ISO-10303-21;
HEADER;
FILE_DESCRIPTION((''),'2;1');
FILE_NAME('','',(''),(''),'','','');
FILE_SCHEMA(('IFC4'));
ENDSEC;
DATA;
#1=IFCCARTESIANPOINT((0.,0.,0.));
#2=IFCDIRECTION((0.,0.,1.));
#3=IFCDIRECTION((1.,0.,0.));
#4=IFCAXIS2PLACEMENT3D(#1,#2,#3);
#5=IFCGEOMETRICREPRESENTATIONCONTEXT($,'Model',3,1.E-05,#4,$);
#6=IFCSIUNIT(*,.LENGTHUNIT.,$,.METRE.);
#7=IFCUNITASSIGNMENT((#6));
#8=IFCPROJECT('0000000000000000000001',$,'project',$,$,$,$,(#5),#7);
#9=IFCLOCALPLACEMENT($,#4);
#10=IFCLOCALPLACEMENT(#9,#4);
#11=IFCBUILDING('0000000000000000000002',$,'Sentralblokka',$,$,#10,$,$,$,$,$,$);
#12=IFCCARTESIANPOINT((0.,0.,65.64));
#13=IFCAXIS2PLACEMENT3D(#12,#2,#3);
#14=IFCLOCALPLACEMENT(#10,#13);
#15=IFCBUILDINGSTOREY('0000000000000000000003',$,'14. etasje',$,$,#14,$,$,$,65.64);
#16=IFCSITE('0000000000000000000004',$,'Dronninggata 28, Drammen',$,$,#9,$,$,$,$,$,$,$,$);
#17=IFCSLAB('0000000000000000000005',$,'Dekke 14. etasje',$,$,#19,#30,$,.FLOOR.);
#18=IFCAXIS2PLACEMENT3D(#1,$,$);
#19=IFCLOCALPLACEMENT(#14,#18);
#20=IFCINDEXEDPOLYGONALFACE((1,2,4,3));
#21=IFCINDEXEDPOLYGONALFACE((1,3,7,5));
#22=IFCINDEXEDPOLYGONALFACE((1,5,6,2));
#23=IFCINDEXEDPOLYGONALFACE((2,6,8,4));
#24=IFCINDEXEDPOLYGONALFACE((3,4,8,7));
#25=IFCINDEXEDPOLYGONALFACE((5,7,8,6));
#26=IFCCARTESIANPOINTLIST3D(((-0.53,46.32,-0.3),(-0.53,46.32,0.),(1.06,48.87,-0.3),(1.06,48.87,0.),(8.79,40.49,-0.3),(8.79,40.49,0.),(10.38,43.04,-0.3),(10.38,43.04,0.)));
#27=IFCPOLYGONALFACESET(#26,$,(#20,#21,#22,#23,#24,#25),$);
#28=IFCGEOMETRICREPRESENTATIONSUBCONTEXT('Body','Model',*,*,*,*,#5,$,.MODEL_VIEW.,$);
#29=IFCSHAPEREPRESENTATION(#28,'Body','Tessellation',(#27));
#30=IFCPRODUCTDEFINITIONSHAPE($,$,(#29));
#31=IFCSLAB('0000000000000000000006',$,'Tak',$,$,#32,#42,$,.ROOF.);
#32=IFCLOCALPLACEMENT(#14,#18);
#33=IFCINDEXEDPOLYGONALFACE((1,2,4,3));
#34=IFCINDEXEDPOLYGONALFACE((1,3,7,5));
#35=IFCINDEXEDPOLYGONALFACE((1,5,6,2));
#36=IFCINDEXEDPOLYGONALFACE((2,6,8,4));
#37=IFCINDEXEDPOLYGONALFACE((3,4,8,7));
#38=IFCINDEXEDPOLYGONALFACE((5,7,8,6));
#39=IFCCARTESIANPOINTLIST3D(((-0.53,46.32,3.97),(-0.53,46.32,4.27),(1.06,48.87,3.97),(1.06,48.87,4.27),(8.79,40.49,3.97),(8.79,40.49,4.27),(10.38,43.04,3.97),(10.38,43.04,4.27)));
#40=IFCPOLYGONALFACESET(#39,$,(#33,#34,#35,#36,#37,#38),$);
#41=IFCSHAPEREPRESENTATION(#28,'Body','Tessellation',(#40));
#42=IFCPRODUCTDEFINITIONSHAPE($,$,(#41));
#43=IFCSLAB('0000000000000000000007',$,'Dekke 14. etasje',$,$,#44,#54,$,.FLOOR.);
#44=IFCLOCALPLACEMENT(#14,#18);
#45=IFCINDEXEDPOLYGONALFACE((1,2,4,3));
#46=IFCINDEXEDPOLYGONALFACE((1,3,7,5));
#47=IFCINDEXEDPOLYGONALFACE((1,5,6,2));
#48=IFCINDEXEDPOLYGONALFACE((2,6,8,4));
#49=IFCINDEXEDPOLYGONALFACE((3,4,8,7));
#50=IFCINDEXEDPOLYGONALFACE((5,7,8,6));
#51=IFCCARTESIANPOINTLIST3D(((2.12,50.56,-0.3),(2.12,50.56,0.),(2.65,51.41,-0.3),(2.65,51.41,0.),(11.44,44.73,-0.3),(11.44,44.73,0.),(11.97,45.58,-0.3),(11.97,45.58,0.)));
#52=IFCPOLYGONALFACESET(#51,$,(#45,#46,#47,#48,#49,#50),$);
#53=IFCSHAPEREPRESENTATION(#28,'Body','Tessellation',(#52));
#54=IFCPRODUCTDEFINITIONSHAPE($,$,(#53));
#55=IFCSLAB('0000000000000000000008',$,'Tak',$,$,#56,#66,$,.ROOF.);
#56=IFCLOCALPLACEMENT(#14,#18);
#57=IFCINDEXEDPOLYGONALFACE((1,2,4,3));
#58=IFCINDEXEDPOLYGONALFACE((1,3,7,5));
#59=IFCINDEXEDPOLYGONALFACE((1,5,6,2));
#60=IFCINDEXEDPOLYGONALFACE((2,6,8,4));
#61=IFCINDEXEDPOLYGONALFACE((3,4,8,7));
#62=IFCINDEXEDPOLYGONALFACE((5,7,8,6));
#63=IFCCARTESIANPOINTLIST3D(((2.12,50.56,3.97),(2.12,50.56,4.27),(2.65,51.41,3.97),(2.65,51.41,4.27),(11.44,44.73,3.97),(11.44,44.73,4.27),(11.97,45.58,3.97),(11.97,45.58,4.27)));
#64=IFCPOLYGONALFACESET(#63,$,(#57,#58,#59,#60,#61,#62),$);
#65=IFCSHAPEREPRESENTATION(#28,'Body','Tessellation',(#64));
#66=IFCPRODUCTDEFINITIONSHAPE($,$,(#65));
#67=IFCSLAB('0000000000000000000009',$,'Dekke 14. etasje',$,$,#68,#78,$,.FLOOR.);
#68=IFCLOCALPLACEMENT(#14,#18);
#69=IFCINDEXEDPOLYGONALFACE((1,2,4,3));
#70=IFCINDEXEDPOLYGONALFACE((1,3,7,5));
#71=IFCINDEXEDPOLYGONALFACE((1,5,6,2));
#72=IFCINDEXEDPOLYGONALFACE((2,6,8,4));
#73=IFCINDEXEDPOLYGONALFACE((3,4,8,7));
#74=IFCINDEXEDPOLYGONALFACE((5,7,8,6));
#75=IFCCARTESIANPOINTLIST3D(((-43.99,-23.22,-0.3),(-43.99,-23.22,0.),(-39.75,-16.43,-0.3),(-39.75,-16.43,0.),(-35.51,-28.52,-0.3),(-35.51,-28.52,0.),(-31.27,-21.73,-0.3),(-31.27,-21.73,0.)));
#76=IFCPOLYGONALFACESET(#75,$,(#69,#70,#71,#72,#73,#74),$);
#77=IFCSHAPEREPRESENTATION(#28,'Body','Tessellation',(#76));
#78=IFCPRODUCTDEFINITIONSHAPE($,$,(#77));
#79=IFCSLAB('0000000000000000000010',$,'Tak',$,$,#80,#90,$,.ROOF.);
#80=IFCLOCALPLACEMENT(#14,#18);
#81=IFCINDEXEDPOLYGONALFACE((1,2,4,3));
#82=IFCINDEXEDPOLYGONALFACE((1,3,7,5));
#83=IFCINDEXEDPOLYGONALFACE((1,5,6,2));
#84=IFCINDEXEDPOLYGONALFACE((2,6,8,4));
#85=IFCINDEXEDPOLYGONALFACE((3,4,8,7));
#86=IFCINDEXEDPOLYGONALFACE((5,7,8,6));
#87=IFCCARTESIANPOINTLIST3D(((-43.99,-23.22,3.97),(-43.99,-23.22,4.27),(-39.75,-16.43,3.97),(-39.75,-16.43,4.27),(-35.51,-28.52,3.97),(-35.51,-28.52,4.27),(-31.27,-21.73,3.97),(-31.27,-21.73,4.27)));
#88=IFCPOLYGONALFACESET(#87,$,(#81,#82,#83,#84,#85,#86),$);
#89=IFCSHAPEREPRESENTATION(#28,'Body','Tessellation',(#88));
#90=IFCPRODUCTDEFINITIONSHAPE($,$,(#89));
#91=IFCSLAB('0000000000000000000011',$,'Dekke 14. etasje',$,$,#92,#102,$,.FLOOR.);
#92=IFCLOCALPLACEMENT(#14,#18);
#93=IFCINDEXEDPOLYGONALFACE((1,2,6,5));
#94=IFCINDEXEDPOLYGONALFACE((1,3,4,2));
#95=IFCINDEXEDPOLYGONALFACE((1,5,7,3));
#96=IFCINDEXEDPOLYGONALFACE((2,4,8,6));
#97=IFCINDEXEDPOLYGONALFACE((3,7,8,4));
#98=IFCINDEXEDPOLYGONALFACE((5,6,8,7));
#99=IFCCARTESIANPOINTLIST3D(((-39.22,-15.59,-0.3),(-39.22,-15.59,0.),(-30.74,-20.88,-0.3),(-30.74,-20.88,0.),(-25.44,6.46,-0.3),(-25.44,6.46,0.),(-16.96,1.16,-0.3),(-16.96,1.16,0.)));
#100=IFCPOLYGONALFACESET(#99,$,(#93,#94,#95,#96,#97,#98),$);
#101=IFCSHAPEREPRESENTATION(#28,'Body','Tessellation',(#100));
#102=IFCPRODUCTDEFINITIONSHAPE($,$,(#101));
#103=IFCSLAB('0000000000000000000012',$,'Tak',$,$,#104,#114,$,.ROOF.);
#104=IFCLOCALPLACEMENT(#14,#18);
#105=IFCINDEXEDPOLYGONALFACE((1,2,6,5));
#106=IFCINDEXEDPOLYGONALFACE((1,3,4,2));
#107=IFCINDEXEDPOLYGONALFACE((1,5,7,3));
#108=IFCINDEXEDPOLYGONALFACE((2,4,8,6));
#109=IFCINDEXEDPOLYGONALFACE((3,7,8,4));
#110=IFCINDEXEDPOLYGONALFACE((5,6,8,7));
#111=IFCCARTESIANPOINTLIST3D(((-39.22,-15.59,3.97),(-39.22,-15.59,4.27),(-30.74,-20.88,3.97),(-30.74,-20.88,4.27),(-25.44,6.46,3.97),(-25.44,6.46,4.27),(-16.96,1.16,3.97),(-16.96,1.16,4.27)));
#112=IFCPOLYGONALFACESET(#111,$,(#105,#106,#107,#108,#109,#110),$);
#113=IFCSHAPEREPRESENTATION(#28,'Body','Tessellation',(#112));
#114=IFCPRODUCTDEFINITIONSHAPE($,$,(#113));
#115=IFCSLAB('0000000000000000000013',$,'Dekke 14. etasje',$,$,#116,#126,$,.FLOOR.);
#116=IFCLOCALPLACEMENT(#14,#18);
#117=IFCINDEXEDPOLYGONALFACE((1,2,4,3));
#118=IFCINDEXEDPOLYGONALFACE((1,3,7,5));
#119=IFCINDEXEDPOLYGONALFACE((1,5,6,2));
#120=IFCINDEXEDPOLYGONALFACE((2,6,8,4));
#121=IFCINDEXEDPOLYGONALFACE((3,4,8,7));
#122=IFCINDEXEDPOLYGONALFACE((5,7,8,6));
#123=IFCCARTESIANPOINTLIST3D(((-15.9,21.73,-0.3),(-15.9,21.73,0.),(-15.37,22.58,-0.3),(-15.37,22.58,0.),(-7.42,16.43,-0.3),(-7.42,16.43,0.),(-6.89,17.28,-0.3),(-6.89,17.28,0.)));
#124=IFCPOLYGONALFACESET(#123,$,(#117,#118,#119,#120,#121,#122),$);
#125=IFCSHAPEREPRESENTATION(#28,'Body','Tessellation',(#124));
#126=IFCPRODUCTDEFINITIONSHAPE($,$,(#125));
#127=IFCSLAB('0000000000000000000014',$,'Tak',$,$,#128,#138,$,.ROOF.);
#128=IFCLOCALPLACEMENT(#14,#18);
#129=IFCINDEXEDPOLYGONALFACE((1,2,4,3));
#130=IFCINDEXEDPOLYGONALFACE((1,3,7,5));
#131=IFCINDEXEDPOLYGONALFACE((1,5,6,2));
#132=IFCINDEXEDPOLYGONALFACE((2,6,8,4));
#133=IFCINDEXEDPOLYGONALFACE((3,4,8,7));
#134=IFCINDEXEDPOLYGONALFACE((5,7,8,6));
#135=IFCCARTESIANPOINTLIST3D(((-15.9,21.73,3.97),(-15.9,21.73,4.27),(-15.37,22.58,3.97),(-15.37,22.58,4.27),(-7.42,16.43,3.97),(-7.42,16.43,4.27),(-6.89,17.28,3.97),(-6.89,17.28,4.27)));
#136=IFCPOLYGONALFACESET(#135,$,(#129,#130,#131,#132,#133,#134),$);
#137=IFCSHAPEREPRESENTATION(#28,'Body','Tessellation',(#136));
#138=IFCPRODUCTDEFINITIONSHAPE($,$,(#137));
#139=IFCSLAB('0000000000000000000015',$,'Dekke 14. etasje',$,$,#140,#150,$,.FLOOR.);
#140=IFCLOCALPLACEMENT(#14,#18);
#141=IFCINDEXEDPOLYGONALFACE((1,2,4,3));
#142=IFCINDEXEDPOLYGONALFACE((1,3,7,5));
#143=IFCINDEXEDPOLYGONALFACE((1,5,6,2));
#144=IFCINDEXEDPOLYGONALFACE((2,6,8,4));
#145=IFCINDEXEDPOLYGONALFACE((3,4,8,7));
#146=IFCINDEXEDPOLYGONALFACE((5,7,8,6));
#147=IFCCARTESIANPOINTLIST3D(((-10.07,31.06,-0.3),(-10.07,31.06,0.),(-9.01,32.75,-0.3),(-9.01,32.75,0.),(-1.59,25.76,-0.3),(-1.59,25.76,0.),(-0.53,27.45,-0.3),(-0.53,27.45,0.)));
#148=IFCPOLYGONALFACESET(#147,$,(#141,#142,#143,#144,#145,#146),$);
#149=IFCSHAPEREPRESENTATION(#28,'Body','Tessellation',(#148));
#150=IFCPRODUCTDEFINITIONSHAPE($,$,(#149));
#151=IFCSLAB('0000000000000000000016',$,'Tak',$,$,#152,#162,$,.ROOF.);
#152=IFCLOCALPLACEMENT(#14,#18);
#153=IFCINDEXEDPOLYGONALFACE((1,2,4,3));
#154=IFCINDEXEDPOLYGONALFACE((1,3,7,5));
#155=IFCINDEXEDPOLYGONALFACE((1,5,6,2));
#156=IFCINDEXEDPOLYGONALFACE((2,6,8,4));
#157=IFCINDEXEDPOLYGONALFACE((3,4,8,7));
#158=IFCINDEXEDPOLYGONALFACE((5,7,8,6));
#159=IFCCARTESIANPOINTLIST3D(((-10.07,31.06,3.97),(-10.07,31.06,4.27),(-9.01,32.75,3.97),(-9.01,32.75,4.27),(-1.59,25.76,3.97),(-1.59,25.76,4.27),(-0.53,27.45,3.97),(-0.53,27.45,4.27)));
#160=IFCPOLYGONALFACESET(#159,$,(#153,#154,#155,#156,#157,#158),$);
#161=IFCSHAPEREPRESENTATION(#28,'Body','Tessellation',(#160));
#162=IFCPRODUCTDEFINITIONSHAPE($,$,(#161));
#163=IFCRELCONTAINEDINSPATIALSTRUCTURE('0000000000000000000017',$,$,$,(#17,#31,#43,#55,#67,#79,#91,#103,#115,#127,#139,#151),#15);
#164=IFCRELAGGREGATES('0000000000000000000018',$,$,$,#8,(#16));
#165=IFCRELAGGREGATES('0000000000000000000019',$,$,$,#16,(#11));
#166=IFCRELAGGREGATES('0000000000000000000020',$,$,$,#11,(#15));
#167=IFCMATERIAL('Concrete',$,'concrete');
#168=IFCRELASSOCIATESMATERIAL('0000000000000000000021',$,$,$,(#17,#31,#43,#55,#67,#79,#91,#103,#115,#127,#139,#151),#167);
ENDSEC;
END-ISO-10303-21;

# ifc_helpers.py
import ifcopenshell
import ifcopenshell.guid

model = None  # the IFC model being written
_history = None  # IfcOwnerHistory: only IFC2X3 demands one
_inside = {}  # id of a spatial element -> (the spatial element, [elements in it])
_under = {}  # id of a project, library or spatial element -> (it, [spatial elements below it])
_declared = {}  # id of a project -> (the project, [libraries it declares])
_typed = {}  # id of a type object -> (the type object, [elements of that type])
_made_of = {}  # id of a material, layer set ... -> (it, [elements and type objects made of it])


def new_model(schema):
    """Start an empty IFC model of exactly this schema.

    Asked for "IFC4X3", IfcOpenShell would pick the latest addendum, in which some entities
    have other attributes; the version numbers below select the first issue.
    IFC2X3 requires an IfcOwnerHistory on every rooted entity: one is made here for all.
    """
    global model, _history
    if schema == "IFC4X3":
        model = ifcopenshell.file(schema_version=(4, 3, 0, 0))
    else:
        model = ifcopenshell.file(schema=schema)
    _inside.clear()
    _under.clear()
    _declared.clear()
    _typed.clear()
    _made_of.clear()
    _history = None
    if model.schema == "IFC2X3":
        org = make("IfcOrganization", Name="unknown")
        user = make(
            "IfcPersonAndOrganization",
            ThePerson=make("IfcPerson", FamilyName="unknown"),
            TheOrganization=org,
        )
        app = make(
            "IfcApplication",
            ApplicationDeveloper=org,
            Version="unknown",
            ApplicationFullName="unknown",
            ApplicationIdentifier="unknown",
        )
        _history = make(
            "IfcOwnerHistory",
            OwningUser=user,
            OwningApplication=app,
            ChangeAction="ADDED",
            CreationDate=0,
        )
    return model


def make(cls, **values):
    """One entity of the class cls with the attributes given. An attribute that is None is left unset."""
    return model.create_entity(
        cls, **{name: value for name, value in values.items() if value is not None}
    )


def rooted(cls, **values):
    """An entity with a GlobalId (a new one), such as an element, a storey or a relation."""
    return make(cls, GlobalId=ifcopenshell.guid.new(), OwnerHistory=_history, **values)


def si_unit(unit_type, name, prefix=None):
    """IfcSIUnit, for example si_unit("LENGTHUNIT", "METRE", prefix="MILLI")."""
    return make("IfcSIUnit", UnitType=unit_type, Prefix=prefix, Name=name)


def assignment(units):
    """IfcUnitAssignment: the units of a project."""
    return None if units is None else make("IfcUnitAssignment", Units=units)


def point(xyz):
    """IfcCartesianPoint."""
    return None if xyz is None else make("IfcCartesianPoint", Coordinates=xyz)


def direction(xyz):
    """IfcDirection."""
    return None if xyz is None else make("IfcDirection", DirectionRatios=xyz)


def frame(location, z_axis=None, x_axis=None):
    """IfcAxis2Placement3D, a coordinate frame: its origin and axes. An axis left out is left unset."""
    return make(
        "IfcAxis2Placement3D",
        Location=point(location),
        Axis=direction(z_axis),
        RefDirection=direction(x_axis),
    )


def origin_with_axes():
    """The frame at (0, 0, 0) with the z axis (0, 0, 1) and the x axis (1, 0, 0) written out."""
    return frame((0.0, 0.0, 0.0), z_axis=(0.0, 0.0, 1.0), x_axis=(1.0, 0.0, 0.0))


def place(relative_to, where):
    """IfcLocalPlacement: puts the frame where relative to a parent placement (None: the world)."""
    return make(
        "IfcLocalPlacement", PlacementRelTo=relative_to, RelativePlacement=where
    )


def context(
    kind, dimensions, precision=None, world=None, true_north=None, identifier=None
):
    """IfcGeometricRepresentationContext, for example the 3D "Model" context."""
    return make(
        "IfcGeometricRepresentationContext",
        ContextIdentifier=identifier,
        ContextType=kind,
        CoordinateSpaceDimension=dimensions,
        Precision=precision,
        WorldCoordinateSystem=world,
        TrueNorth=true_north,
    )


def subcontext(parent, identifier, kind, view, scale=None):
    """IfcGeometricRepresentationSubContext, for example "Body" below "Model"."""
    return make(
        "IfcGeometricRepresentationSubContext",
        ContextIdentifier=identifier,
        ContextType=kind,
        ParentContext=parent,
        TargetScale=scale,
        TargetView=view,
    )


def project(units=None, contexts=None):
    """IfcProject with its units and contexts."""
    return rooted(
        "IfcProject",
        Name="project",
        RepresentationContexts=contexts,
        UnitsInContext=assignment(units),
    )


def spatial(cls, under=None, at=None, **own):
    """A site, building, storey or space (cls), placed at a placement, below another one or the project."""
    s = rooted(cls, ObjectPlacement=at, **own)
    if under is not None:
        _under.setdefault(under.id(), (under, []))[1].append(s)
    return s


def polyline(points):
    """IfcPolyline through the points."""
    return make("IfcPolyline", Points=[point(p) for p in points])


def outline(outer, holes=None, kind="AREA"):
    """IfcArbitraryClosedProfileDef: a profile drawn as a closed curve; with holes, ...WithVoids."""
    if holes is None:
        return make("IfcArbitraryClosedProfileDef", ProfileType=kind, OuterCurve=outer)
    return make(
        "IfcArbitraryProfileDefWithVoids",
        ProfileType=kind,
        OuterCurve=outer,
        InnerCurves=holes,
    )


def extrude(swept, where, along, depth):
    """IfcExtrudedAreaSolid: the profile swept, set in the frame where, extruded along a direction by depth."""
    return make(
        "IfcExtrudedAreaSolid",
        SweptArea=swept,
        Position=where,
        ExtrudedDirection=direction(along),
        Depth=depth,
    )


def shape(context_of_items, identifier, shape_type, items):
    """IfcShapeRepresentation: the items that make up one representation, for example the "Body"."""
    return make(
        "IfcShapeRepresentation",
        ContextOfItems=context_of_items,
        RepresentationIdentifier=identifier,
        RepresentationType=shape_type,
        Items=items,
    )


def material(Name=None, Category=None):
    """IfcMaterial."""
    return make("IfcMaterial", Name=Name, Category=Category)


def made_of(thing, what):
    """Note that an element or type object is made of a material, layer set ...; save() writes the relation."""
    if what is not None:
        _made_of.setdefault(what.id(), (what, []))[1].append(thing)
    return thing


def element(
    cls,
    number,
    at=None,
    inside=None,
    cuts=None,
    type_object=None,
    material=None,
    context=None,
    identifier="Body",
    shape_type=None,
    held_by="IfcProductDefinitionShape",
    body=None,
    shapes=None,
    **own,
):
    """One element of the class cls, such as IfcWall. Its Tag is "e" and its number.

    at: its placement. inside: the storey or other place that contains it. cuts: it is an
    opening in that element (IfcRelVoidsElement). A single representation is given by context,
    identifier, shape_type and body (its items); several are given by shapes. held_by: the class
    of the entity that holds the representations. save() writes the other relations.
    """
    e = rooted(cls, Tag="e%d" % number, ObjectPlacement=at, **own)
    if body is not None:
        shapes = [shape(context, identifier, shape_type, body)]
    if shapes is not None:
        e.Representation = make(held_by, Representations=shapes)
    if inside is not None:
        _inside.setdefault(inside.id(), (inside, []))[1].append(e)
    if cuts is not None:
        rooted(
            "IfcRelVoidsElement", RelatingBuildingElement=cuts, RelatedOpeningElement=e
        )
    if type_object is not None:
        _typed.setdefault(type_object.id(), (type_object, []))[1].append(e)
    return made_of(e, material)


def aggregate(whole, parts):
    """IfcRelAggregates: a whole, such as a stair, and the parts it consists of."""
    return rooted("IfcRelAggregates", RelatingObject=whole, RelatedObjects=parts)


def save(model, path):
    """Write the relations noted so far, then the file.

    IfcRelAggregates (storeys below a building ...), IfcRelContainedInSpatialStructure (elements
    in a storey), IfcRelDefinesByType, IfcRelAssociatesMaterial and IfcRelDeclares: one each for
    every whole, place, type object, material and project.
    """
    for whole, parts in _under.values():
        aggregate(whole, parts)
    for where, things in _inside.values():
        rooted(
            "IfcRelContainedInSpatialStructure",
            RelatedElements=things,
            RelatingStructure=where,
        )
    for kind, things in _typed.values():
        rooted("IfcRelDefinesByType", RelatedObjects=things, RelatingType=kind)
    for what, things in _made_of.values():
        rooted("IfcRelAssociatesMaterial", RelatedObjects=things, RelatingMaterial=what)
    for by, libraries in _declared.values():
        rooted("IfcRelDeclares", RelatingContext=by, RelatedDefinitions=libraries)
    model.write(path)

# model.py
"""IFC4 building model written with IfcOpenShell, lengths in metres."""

from ifc_helpers import new_model, si_unit, frame, origin_with_axes, place, context, subcontext, project, spatial, polyline, outline, extrude, material, element, save


model = new_model("IFC4")

# Units and contexts
model_context = context("Model", 3, precision=1e-05, world=origin_with_axes())
body_context = subcontext(model_context, "Body", "Model", "MODEL_VIEW")
ifc_project = project(units=[si_unit("LENGTHUNIT", "METRE")], contexts=[model_context])

# Site, building, storey
site_placement = place(None, origin_with_axes())
site = spatial("IfcSite", under=ifc_project, at=site_placement, Name="Dronninggata 28, Drammen")
building_placement = place(site_placement, origin_with_axes())
building = spatial("IfcBuilding", under=site, at=building_placement, Name="Sentralblokka")
storey_placement = place(building_placement, frame((0.0, 0.0, 65.64), z_axis=(0.0, 0.0, 1.0), x_axis=(1.0, 0.0, 0.0)))
storey = spatial("IfcBuildingStorey", under=building, at=storey_placement, Name="14. etasje", Elevation=65.64)

# Slabs
ifc_material = material(Name="Concrete", Category="concrete")
slab_1_placement = place(storey_placement, frame((0.0, 0.0, -65.64), z_axis=(0.0, 0.0, 1.0), x_axis=(1.0, 0.0, 0.0)))
element("IfcSlab", 1, at=slab_1_placement, inside=storey, material=ifc_material, Name="Dekke 14. etasje", PredefinedType="FLOOR", context=body_context, shape_type="SweptSolid", body=[
    extrude(outline(polyline([(8.79, 40.49), (10.38, 43.04), (1.06, 48.87), (-0.53, 46.32), (8.79, 40.49)])), frame((0.0, 0.0, 65.34)), (0.0, 0.0, 1.0), 0.3),
])
slab_2_placement = place(storey_placement, frame((0.0, 0.0, -65.64), z_axis=(0.0, 0.0, 1.0), x_axis=(1.0, 0.0, 0.0)))
element("IfcSlab", 2, at=slab_2_placement, inside=storey, material=ifc_material, Name="Tak", PredefinedType="ROOF", context=body_context, shape_type="SweptSolid", body=[
    extrude(outline(polyline([(8.79, 40.49), (10.38, 43.04), (1.06, 48.87), (-0.53, 46.32), (8.79, 40.49)])), frame((0.0, 0.0, 69.61)), (0.0, 0.0, 1.0), 0.3),
])
slab_3_placement = place(storey_placement, frame((0.0, 0.0, -65.64), z_axis=(0.0, 0.0, 1.0), x_axis=(1.0, 0.0, 0.0)))
element("IfcSlab", 3, at=slab_3_placement, inside=storey, material=ifc_material, Name="Dekke 14. etasje", PredefinedType="FLOOR", context=body_context, shape_type="SweptSolid", body=[
    extrude(outline(polyline([(11.44, 44.73), (11.97, 45.58), (2.65, 51.41), (2.12, 50.56), (11.44, 44.73)])), frame((0.0, 0.0, 65.34)), (0.0, 0.0, 1.0), 0.3),
])
slab_4_placement = place(storey_placement, frame((0.0, 0.0, -65.64), z_axis=(0.0, 0.0, 1.0), x_axis=(1.0, 0.0, 0.0)))
element("IfcSlab", 4, at=slab_4_placement, inside=storey, material=ifc_material, Name="Tak", PredefinedType="ROOF", context=body_context, shape_type="SweptSolid", body=[
    extrude(outline(polyline([(11.44, 44.73), (11.97, 45.58), (2.65, 51.41), (2.12, 50.56), (11.44, 44.73)])), frame((0.0, 0.0, 69.61)), (0.0, 0.0, 1.0), 0.3),
])
slab_5_placement = place(storey_placement, frame((0.0, 0.0, -65.64), z_axis=(0.0, 0.0, 1.0), x_axis=(1.0, 0.0, 0.0)))
element("IfcSlab", 5, at=slab_5_placement, inside=storey, material=ifc_material, Name="Dekke 14. etasje", PredefinedType="FLOOR", context=body_context, shape_type="SweptSolid", body=[
    extrude(outline(polyline([(-35.51, -28.52), (-31.27, -21.73), (-39.75, -16.43), (-43.99, -23.22), (-35.51, -28.52)])), frame((0.0, 0.0, 65.34)), (0.0, 0.0, 1.0), 0.3),
])
slab_6_placement = place(storey_placement, frame((0.0, 0.0, -65.64), z_axis=(0.0, 0.0, 1.0), x_axis=(1.0, 0.0, 0.0)))
element("IfcSlab", 6, at=slab_6_placement, inside=storey, material=ifc_material, Name="Tak", PredefinedType="ROOF", context=body_context, shape_type="SweptSolid", body=[
    extrude(outline(polyline([(-35.51, -28.52), (-31.27, -21.73), (-39.75, -16.43), (-43.99, -23.22), (-35.51, -28.52)])), frame((0.0, 0.0, 69.61)), (0.0, 0.0, 1.0), 0.3),
])
slab_7_placement = place(storey_placement, frame((0.0, 0.0, -65.64), z_axis=(0.0, 0.0, 1.0), x_axis=(1.0, 0.0, 0.0)))
element("IfcSlab", 7, at=slab_7_placement, inside=storey, material=ifc_material, Name="Dekke 14. etasje", PredefinedType="FLOOR", context=body_context, shape_type="SweptSolid", body=[
    extrude(outline(polyline([(-30.74, -20.88), (-16.96, 1.16), (-25.44, 6.46), (-39.22, -15.59), (-30.74, -20.88)])), frame((0.0, 0.0, 65.34)), (0.0, 0.0, 1.0), 0.3),
])
slab_8_placement = place(storey_placement, frame((0.0, 0.0, -65.64), z_axis=(0.0, 0.0, 1.0), x_axis=(1.0, 0.0, 0.0)))
element("IfcSlab", 8, at=slab_8_placement, inside=storey, material=ifc_material, Name="Tak", PredefinedType="ROOF", context=body_context, shape_type="SweptSolid", body=[
    extrude(outline(polyline([(-30.74, -20.88), (-16.96, 1.16), (-25.44, 6.46), (-39.22, -15.59), (-30.74, -20.88)])), frame((0.0, 0.0, 69.61)), (0.0, 0.0, 1.0), 0.3),
])
slab_9_placement = place(storey_placement, frame((0.0, 0.0, -65.64), z_axis=(0.0, 0.0, 1.0), x_axis=(1.0, 0.0, 0.0)))
element("IfcSlab", 9, at=slab_9_placement, inside=storey, material=ifc_material, Name="Dekke 14. etasje", PredefinedType="FLOOR", context=body_context, shape_type="SweptSolid", body=[
    extrude(outline(polyline([(-7.42, 16.43), (-6.89, 17.28), (-15.37, 22.58), (-15.9, 21.73), (-7.42, 16.43)])), frame((0.0, 0.0, 65.34)), (0.0, 0.0, 1.0), 0.3),
])
slab_10_placement = place(storey_placement, frame((0.0, 0.0, -65.64), z_axis=(0.0, 0.0, 1.0), x_axis=(1.0, 0.0, 0.0)))
element("IfcSlab", 10, at=slab_10_placement, inside=storey, material=ifc_material, Name="Tak", PredefinedType="ROOF", context=body_context, shape_type="SweptSolid", body=[
    extrude(outline(polyline([(-7.42, 16.43), (-6.89, 17.28), (-15.37, 22.58), (-15.9, 21.73), (-7.42, 16.43)])), frame((0.0, 0.0, 69.61)), (0.0, 0.0, 1.0), 0.3),
])
slab_11_placement = place(storey_placement, frame((0.0, 0.0, -65.64), z_axis=(0.0, 0.0, 1.0), x_axis=(1.0, 0.0, 0.0)))
element("IfcSlab", 11, at=slab_11_placement, inside=storey, material=ifc_material, Name="Dekke 14. etasje", PredefinedType="FLOOR", context=body_context, shape_type="SweptSolid", body=[
    extrude(outline(polyline([(-1.59, 25.76), (-0.53, 27.45), (-9.01, 32.75), (-10.07, 31.06), (-1.59, 25.76)])), frame((0.0, 0.0, 65.34)), (0.0, 0.0, 1.0), 0.3),
])
slab_12_placement = place(storey_placement, frame((0.0, 0.0, -65.64), z_axis=(0.0, 0.0, 1.0), x_axis=(1.0, 0.0, 0.0)))
element("IfcSlab", 12, at=slab_12_placement, inside=storey, material=ifc_material, Name="Tak", PredefinedType="ROOF", context=body_context, shape_type="SweptSolid", body=[
    extrude(outline(polyline([(-1.59, 25.76), (-0.53, 27.45), (-9.01, 32.75), (-10.07, 31.06), (-1.59, 25.76)])), frame((0.0, 0.0, 69.61)), (0.0, 0.0, 1.0), 0.3),
])

save(model, "model.ifc")
